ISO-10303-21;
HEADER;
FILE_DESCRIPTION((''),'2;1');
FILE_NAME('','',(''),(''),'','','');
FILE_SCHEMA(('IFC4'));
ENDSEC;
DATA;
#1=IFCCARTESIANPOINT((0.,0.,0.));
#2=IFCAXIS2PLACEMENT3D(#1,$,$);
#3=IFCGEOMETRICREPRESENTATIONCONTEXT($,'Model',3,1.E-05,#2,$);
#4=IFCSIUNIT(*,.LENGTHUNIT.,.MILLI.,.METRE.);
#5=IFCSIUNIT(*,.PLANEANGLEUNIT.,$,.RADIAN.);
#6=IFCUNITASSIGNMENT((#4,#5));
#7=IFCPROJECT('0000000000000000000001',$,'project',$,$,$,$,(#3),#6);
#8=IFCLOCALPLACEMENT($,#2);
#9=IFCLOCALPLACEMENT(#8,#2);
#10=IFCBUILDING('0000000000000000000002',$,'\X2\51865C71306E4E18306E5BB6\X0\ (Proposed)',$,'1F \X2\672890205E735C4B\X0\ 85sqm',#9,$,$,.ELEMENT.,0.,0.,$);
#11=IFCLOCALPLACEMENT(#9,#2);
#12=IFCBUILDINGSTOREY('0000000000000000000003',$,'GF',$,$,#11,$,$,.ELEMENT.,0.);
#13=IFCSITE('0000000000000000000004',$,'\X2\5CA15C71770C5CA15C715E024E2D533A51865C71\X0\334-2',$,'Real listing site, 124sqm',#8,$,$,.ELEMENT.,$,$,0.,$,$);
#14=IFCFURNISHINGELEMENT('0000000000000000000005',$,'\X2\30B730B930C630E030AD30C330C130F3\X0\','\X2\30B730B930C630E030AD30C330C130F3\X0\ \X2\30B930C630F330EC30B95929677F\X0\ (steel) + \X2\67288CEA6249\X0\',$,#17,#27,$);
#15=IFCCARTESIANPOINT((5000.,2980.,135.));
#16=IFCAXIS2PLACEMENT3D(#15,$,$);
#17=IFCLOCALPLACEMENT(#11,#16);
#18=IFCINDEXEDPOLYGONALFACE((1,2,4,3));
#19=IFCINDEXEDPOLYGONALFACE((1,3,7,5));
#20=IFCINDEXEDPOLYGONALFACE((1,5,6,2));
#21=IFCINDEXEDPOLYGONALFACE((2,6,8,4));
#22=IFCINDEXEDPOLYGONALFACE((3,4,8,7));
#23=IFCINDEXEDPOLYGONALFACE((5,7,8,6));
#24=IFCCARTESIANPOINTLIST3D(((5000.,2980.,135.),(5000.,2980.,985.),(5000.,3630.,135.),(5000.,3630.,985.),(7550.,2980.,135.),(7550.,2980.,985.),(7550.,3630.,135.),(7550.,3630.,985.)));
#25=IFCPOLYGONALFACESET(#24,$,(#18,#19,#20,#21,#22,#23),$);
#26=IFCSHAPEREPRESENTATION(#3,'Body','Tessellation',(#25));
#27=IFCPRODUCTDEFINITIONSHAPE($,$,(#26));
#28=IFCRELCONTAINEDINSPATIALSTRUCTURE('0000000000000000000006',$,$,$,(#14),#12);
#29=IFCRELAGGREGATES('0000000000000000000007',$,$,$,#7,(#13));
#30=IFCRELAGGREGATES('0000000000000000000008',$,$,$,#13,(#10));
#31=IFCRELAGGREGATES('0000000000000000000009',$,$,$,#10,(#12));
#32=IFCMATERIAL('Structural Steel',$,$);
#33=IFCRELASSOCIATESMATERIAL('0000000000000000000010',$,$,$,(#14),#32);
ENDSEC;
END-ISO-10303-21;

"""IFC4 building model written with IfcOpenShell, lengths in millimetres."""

from ifc_helpers import new_model, si_unit, frame, frame_2d, origin, place, context, project, spatial, rectangle, extrude, material, element, save


model = new_model("IFC4")

# Units and contexts
model_context = context("Model", 3, precision=1e-05, world=origin())
ifc_project = project(units=[si_unit("LENGTHUNIT", "METRE", prefix="MILLI"), si_unit("PLANEANGLEUNIT", "RADIAN")], contexts=[model_context])

# Site, building, storey
site_placement = place(None, origin())
site = spatial("IfcSite", under=ifc_project, at=site_placement, Name="岡山県岡山市中区円山334-2", ObjectType="Real listing site, 124sqm", CompositionType="ELEMENT", RefElevation=0.0)
building_placement = place(site_placement, origin())
building = spatial("IfcBuilding", under=site, at=building_placement, Name="円山の丘の家 (Proposed)", ObjectType="1F 木造平屋 85sqm", CompositionType="ELEMENT", ElevationOfRefHeight=0.0, ElevationOfTerrain=0.0)
storey_placement = place(building_placement, origin())
storey = spatial("IfcBuildingStorey", under=building, at=storey_placement, Name="GF", CompositionType="ELEMENT", Elevation=0.0)

# Furnishing element
ifc_material_1 = material(Name="Structural Steel")
furnishing_1_placement = place(storey_placement, frame((5000.0, 2980.0, 135.0)))
element("IfcFurnishingElement", 1, at=furnishing_1_placement, inside=storey, material=ifc_material_1, Name="システムキッチン", Description="システムキッチン ステンレス天板 (steel) + 木質扉", context=model_context, shape_type="SweptSolid", body=[
    extrude(rectangle(XDim=2550.0, YDim=650.0, at=frame_2d((1275.0, 325.0))), frame((5000.0, 2980.0, 135.0)), (0.0, 0.0, 1.0), 850.0),
])

save(model, "model.ifc")
